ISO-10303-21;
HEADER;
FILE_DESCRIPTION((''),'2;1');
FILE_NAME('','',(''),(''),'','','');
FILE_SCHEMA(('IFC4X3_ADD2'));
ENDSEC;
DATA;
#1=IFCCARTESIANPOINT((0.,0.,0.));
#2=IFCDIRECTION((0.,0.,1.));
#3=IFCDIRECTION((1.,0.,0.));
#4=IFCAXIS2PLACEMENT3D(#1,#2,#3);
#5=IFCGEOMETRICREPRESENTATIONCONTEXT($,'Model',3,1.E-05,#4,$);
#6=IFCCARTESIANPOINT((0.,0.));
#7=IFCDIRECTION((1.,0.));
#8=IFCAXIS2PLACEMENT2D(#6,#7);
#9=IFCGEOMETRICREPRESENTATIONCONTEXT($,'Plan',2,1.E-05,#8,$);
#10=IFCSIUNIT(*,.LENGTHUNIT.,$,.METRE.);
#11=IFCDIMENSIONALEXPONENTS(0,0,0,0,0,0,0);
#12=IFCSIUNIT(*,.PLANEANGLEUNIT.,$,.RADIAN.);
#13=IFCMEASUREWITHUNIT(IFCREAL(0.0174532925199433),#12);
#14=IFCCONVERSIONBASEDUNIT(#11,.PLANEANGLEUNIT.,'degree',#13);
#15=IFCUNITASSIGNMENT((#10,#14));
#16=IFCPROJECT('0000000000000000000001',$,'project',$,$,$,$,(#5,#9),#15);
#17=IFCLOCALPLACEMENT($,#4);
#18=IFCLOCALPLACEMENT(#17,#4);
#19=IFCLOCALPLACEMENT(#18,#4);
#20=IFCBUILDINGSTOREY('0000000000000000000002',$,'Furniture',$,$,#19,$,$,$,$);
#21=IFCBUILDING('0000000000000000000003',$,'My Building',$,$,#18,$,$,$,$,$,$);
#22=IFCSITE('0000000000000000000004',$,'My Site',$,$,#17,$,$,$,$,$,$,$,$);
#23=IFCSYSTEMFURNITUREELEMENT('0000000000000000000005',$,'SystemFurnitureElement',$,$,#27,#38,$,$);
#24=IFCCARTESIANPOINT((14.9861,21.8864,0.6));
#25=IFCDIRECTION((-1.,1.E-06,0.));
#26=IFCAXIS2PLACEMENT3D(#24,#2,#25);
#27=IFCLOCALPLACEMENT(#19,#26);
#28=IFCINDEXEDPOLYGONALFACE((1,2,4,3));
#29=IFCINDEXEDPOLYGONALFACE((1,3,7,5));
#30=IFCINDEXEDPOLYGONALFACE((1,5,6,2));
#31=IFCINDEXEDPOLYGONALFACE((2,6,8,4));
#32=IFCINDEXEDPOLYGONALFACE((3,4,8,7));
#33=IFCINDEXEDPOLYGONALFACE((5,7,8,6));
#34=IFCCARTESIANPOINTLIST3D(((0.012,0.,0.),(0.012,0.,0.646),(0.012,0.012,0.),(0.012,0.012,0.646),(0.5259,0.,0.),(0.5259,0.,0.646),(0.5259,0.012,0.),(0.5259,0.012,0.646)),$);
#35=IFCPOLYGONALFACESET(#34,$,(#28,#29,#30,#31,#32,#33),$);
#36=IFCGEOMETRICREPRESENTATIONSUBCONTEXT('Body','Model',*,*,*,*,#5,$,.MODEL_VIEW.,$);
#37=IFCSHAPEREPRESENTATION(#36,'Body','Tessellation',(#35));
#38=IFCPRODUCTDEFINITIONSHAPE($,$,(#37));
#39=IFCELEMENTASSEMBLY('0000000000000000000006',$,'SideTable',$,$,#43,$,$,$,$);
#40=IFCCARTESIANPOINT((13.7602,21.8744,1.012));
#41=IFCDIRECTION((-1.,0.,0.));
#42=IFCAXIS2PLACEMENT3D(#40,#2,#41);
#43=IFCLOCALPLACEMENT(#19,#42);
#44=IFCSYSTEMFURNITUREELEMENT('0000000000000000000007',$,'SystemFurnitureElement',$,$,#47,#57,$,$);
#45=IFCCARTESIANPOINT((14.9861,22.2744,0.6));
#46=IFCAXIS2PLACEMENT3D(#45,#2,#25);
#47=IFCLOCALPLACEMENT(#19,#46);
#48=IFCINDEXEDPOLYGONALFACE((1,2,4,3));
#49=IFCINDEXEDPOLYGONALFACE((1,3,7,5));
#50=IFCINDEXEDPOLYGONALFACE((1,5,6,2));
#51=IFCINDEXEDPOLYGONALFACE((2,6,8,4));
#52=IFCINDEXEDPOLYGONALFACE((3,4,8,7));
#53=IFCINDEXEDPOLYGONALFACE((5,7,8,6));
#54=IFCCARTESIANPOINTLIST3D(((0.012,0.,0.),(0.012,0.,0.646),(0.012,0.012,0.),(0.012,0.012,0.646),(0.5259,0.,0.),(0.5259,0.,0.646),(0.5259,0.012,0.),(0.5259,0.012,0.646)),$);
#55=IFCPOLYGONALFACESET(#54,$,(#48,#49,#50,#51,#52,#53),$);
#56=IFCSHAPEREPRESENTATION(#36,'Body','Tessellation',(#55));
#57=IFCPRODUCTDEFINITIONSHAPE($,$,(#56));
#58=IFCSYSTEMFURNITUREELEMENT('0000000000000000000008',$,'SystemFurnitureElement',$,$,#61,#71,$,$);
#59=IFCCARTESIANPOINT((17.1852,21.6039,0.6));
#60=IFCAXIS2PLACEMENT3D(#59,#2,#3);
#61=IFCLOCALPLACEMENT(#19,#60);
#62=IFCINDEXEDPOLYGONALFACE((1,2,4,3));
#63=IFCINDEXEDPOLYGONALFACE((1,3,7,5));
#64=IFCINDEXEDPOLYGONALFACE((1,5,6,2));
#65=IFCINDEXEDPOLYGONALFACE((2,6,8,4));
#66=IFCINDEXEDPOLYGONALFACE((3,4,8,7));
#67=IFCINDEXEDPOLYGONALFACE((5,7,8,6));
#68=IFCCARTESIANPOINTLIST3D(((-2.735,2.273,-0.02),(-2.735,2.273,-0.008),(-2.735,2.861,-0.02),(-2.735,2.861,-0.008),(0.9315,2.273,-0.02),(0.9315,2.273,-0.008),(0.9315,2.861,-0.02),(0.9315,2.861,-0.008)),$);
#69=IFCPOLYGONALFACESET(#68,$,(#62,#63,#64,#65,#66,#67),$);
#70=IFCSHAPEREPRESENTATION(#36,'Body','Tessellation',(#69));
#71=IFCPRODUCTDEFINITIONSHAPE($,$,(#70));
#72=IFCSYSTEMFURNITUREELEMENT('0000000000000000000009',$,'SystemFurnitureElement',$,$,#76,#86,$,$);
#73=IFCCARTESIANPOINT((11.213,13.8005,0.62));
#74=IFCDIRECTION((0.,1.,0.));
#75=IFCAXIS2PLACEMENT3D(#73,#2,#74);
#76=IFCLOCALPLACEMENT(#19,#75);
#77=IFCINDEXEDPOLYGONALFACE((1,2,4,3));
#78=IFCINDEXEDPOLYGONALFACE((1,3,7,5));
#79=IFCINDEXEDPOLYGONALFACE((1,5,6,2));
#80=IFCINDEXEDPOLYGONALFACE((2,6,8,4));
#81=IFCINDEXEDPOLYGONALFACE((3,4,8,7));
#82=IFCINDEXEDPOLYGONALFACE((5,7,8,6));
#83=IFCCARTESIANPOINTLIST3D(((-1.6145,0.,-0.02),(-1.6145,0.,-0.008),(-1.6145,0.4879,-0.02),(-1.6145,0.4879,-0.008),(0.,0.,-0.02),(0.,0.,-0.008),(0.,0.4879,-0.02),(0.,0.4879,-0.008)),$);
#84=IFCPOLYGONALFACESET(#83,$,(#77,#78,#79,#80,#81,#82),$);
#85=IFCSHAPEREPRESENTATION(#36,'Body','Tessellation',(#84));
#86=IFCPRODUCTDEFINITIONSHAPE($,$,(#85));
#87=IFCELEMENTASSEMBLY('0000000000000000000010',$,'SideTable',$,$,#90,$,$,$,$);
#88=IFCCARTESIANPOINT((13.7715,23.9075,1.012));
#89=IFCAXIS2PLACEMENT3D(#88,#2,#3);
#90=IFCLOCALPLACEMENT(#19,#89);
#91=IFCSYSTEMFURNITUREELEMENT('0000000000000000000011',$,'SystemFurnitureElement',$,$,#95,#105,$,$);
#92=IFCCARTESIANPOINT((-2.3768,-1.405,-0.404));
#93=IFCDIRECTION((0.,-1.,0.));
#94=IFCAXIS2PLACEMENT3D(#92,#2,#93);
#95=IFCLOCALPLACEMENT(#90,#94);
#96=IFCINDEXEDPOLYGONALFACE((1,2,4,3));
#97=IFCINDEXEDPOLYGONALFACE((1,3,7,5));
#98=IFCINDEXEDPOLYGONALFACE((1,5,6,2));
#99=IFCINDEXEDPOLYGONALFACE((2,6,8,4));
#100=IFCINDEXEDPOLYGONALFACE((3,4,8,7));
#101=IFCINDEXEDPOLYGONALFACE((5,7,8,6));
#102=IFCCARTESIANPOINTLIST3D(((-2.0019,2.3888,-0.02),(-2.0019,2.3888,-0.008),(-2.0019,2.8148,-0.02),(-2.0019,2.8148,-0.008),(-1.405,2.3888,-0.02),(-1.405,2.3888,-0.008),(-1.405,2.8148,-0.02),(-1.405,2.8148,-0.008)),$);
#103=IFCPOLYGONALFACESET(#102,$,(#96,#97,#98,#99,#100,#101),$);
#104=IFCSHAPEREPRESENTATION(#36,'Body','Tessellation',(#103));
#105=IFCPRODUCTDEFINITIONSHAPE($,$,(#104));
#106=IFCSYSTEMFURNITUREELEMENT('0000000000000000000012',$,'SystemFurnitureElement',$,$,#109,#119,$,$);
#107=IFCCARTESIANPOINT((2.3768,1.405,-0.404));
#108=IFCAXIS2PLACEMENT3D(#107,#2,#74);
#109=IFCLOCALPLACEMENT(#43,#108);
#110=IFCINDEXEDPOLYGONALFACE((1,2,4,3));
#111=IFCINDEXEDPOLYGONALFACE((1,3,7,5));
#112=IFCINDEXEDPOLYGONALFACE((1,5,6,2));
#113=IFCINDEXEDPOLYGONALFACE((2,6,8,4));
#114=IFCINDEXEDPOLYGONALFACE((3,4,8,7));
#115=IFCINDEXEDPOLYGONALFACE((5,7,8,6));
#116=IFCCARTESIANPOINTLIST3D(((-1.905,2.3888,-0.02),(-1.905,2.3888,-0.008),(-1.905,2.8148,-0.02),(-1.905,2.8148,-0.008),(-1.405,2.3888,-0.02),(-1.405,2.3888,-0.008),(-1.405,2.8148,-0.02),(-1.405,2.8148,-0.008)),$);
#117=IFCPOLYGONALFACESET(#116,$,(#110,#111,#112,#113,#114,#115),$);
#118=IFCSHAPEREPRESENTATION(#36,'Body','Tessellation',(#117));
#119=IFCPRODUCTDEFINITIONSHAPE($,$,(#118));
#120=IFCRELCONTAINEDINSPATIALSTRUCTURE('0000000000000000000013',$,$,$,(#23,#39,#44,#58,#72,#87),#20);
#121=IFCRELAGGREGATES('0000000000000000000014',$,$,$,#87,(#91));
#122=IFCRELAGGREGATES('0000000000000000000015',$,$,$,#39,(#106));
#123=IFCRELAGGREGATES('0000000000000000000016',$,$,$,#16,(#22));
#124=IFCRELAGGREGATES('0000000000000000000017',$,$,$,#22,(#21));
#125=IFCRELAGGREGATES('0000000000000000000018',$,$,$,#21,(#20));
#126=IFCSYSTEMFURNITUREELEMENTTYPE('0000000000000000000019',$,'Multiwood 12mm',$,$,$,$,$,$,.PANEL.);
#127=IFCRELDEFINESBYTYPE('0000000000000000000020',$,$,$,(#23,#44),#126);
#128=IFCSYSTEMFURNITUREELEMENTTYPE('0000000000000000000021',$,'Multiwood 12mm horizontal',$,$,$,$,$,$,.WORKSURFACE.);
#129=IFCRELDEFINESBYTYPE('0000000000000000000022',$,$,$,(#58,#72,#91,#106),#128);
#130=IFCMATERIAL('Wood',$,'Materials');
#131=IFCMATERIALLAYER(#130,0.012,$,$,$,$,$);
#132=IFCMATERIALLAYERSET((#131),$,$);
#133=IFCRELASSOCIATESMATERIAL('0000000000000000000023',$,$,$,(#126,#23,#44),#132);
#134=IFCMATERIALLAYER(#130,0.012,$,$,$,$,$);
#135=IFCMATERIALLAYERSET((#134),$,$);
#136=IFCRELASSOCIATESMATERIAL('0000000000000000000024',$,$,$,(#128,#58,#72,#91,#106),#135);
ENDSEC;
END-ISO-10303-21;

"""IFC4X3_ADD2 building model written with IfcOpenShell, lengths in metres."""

from ifc_helpers import new_model, entity, si_unit, converted_unit, frame, origin_with_axes, origin_2d_with_axis, place, context, subcontext, project, spatial, line, indexed_curve, outline, extrude, material, layer, layer_set, layer_usage, type_object, element, aggregate, save


model = new_model("IFC4X3_ADD2")

# Units and contexts
model_context = context("Model", 3, precision=1e-05, world=origin_with_axes())
plan_context = context("Plan", 2, precision=1e-05, world=origin_2d_with_axis())
body_context = subcontext(model_context, "Body", "Model", "MODEL_VIEW")
ifc_project = project(units=[si_unit("LENGTHUNIT", "METRE"), converted_unit("PLANEANGLEUNIT", "degree", entity("IfcReal", 0.0174532925199433), si_unit("PLANEANGLEUNIT", "RADIAN"), dimensions=[0, 0, 0, 0, 0, 0, 0])], contexts=[model_context, plan_context])

# Site, building, storey
site_placement = place(None, origin_with_axes())
site = spatial("IfcSite", under=ifc_project, at=site_placement, Name="My Site")
building_placement = place(site_placement, origin_with_axes())
building = spatial("IfcBuilding", under=site, at=building_placement, Name="My Building")
storey_placement = place(building_placement, origin_with_axes())
storey = spatial("IfcBuildingStorey", under=building, at=storey_placement, Name="Furniture")

# System furniture element
ifc_material = material(Name="Wood", Category="Materials")
ifc_layer_1 = layer(ifc_material, 0.012)
ifc_layer_set_1 = layer_set([ifc_layer_1])
system_furniture_element_type_1 = type_object("IfcSystemFurnitureElementType", Name="Multiwood 12mm", PredefinedType="PANEL", material=ifc_layer_set_1)
ifc_layer_usage_1 = layer_usage(ifc_layer_set_1, "AXIS2", "POSITIVE", 0.0)
system_furniture_element_1_placement = place(storey_placement, frame((14.9861, 21.8864, 0.6), z_axis=(0.0, 0.0, 1.0), x_axis=(-1.0, 0.000001, 0.0)))
element("IfcSystemFurnitureElement", 1, at=system_furniture_element_1_placement, inside=storey, type_object=system_furniture_element_type_1, material=ifc_layer_usage_1, Name="SystemFurnitureElement", context=body_context, shape_type="SweptSolid", body=[
    extrude(outline(indexed_curve([(0.012, 0.0), (0.012, 0.012), (0.5259, 0.012), (0.5259, 0.0)], segments=[line(1, 2, 3, 4, 1)])), origin_with_axes(), (0.0, 0.0, 1.0), 0.646),
])

# Element assembly
assembly_1_placement = place(storey_placement, frame((13.7602, 21.8744, 1.012), z_axis=(0.0, 0.0, 1.0), x_axis=(-1.0, 0.0, 0.0)))
assembly_1 = element("IfcElementAssembly", 2, at=assembly_1_placement, inside=storey, Name="SideTable")

# System furniture elements
ifc_layer_usage_2 = layer_usage(ifc_layer_set_1, "AXIS2", "POSITIVE", 0.0)
system_furniture_element_2_placement = place(storey_placement, frame((14.9861, 22.2744, 0.6), z_axis=(0.0, 0.0, 1.0), x_axis=(-1.0, 0.000001, 0.0)))
element("IfcSystemFurnitureElement", 3, at=system_furniture_element_2_placement, inside=storey, type_object=system_furniture_element_type_1, material=ifc_layer_usage_2, Name="SystemFurnitureElement", context=body_context, shape_type="SweptSolid", body=[
    extrude(outline(indexed_curve([(0.012, 0.0), (0.012, 0.012), (0.5259, 0.012), (0.5259, 0.0)], segments=[line(1, 2, 3, 4, 1)])), origin_with_axes(), (0.0, 0.0, 1.0), 0.646),
])
ifc_layer_2 = layer(ifc_material, 0.012)
ifc_layer_set_2 = layer_set([ifc_layer_2])
ifc_layer_usage_3 = layer_usage(ifc_layer_set_2, "AXIS3", "POSITIVE", -0.02)
system_furniture_element_type_2 = type_object("IfcSystemFurnitureElementType", Name="Multiwood 12mm horizontal", PredefinedType="WORKSURFACE", material=ifc_layer_set_2)
system_furniture_element_3_placement = place(storey_placement, frame((17.1852, 21.6039, 0.6), z_axis=(0.0, 0.0, 1.0), x_axis=(1.0, 0.0, 0.0)))
element("IfcSystemFurnitureElement", 4, at=system_furniture_element_3_placement, inside=storey, type_object=system_furniture_element_type_2, material=ifc_layer_usage_3, Name="SystemFurnitureElement", context=body_context, shape_type="SweptSolid", body=[
    extrude(outline(indexed_curve([(0.9315, 2.861), (0.9315, 2.273), (-2.735, 2.273), (-2.735, 2.861), (0.9315, 2.861)])), frame((0.0, 0.0, -0.02), z_axis=(0.0, 0.0, 1.0), x_axis=(1.0, 0.0, 0.0)), (0.0, 0.0, 1.0), 0.012),
])
ifc_layer_usage_4 = layer_usage(ifc_layer_set_2, "AXIS3", "POSITIVE", -0.02)
system_furniture_element_4_placement = place(storey_placement, frame((11.213, 13.8005, 0.62), z_axis=(0.0, 0.0, 1.0), x_axis=(0.0, 1.0, 0.0)))
element("IfcSystemFurnitureElement", 5, at=system_furniture_element_4_placement, inside=storey, type_object=system_furniture_element_type_2, material=ifc_layer_usage_4, Name="SystemFurnitureElement", context=body_context, shape_type="SweptSolid", body=[
    extrude(outline(indexed_curve([(0.0, 0.4879), (0.0, 0.0), (-1.6145, 0.0), (-1.6145, 0.4879), (0.0, 0.4879)])), frame((0.0, 0.0, -0.02), z_axis=(0.0, 0.0, 1.0), x_axis=(1.0, 0.0, 0.0)), (0.0, 0.0, 1.0), 0.012),
])

# Element assembly, system furniture element
assembly_2_placement = place(storey_placement, frame((13.7715, 23.9075, 1.012), z_axis=(0.0, 0.0, 1.0), x_axis=(1.0, 0.0, 0.0)))
assembly_2 = element("IfcElementAssembly", 6, at=assembly_2_placement, inside=storey, Name="SideTable")
ifc_layer_usage_5 = layer_usage(ifc_layer_set_2, "AXIS3", "POSITIVE", -0.02)
system_furniture_element_5_placement = place(assembly_2_placement, frame((-2.3768, -1.405, -0.404), z_axis=(0.0, 0.0, 1.0), x_axis=(0.0, -1.0, 0.0)))
system_furniture_element_5 = element("IfcSystemFurnitureElement", 7, at=system_furniture_element_5_placement, type_object=system_furniture_element_type_2, material=ifc_layer_usage_5, Name="SystemFurnitureElement", context=body_context, shape_type="SweptSolid", body=[
    extrude(outline(indexed_curve([(-2.0019, 2.8148), (-2.0019, 2.3888), (-1.405, 2.3888), (-1.405, 2.8148), (-2.0019, 2.8148)])), frame((0.0, 0.0, -0.02), z_axis=(0.0, 0.0, 1.0), x_axis=(1.0, 0.0, 0.0)), (0.0, 0.0, 1.0), 0.012),
])
aggregate(assembly_2, [system_furniture_element_5])

# System furniture element
ifc_layer_usage_6 = layer_usage(ifc_layer_set_2, "AXIS3", "POSITIVE", -0.02)
system_furniture_element_6_placement = place(assembly_1_placement, frame((2.3768, 1.405, -0.404), z_axis=(0.0, 0.0, 1.0), x_axis=(0.0, 1.0, 0.0)))
system_furniture_element_6 = element("IfcSystemFurnitureElement", 8, at=system_furniture_element_6_placement, type_object=system_furniture_element_type_2, material=ifc_layer_usage_6, Name="SystemFurnitureElement", context=body_context, shape_type="SweptSolid", body=[
    extrude(outline(indexed_curve([(-1.405, 2.8148), (-1.405, 2.3888), (-1.905, 2.3888), (-1.905, 2.8148), (-1.405, 2.8148)])), frame((0.0, 0.0, -0.02), z_axis=(0.0, 0.0, 1.0), x_axis=(1.0, 0.0, 0.0)), (0.0, 0.0, 1.0), 0.012),
])
aggregate(assembly_1, [system_furniture_element_6])

save(model, "model.ifc")
